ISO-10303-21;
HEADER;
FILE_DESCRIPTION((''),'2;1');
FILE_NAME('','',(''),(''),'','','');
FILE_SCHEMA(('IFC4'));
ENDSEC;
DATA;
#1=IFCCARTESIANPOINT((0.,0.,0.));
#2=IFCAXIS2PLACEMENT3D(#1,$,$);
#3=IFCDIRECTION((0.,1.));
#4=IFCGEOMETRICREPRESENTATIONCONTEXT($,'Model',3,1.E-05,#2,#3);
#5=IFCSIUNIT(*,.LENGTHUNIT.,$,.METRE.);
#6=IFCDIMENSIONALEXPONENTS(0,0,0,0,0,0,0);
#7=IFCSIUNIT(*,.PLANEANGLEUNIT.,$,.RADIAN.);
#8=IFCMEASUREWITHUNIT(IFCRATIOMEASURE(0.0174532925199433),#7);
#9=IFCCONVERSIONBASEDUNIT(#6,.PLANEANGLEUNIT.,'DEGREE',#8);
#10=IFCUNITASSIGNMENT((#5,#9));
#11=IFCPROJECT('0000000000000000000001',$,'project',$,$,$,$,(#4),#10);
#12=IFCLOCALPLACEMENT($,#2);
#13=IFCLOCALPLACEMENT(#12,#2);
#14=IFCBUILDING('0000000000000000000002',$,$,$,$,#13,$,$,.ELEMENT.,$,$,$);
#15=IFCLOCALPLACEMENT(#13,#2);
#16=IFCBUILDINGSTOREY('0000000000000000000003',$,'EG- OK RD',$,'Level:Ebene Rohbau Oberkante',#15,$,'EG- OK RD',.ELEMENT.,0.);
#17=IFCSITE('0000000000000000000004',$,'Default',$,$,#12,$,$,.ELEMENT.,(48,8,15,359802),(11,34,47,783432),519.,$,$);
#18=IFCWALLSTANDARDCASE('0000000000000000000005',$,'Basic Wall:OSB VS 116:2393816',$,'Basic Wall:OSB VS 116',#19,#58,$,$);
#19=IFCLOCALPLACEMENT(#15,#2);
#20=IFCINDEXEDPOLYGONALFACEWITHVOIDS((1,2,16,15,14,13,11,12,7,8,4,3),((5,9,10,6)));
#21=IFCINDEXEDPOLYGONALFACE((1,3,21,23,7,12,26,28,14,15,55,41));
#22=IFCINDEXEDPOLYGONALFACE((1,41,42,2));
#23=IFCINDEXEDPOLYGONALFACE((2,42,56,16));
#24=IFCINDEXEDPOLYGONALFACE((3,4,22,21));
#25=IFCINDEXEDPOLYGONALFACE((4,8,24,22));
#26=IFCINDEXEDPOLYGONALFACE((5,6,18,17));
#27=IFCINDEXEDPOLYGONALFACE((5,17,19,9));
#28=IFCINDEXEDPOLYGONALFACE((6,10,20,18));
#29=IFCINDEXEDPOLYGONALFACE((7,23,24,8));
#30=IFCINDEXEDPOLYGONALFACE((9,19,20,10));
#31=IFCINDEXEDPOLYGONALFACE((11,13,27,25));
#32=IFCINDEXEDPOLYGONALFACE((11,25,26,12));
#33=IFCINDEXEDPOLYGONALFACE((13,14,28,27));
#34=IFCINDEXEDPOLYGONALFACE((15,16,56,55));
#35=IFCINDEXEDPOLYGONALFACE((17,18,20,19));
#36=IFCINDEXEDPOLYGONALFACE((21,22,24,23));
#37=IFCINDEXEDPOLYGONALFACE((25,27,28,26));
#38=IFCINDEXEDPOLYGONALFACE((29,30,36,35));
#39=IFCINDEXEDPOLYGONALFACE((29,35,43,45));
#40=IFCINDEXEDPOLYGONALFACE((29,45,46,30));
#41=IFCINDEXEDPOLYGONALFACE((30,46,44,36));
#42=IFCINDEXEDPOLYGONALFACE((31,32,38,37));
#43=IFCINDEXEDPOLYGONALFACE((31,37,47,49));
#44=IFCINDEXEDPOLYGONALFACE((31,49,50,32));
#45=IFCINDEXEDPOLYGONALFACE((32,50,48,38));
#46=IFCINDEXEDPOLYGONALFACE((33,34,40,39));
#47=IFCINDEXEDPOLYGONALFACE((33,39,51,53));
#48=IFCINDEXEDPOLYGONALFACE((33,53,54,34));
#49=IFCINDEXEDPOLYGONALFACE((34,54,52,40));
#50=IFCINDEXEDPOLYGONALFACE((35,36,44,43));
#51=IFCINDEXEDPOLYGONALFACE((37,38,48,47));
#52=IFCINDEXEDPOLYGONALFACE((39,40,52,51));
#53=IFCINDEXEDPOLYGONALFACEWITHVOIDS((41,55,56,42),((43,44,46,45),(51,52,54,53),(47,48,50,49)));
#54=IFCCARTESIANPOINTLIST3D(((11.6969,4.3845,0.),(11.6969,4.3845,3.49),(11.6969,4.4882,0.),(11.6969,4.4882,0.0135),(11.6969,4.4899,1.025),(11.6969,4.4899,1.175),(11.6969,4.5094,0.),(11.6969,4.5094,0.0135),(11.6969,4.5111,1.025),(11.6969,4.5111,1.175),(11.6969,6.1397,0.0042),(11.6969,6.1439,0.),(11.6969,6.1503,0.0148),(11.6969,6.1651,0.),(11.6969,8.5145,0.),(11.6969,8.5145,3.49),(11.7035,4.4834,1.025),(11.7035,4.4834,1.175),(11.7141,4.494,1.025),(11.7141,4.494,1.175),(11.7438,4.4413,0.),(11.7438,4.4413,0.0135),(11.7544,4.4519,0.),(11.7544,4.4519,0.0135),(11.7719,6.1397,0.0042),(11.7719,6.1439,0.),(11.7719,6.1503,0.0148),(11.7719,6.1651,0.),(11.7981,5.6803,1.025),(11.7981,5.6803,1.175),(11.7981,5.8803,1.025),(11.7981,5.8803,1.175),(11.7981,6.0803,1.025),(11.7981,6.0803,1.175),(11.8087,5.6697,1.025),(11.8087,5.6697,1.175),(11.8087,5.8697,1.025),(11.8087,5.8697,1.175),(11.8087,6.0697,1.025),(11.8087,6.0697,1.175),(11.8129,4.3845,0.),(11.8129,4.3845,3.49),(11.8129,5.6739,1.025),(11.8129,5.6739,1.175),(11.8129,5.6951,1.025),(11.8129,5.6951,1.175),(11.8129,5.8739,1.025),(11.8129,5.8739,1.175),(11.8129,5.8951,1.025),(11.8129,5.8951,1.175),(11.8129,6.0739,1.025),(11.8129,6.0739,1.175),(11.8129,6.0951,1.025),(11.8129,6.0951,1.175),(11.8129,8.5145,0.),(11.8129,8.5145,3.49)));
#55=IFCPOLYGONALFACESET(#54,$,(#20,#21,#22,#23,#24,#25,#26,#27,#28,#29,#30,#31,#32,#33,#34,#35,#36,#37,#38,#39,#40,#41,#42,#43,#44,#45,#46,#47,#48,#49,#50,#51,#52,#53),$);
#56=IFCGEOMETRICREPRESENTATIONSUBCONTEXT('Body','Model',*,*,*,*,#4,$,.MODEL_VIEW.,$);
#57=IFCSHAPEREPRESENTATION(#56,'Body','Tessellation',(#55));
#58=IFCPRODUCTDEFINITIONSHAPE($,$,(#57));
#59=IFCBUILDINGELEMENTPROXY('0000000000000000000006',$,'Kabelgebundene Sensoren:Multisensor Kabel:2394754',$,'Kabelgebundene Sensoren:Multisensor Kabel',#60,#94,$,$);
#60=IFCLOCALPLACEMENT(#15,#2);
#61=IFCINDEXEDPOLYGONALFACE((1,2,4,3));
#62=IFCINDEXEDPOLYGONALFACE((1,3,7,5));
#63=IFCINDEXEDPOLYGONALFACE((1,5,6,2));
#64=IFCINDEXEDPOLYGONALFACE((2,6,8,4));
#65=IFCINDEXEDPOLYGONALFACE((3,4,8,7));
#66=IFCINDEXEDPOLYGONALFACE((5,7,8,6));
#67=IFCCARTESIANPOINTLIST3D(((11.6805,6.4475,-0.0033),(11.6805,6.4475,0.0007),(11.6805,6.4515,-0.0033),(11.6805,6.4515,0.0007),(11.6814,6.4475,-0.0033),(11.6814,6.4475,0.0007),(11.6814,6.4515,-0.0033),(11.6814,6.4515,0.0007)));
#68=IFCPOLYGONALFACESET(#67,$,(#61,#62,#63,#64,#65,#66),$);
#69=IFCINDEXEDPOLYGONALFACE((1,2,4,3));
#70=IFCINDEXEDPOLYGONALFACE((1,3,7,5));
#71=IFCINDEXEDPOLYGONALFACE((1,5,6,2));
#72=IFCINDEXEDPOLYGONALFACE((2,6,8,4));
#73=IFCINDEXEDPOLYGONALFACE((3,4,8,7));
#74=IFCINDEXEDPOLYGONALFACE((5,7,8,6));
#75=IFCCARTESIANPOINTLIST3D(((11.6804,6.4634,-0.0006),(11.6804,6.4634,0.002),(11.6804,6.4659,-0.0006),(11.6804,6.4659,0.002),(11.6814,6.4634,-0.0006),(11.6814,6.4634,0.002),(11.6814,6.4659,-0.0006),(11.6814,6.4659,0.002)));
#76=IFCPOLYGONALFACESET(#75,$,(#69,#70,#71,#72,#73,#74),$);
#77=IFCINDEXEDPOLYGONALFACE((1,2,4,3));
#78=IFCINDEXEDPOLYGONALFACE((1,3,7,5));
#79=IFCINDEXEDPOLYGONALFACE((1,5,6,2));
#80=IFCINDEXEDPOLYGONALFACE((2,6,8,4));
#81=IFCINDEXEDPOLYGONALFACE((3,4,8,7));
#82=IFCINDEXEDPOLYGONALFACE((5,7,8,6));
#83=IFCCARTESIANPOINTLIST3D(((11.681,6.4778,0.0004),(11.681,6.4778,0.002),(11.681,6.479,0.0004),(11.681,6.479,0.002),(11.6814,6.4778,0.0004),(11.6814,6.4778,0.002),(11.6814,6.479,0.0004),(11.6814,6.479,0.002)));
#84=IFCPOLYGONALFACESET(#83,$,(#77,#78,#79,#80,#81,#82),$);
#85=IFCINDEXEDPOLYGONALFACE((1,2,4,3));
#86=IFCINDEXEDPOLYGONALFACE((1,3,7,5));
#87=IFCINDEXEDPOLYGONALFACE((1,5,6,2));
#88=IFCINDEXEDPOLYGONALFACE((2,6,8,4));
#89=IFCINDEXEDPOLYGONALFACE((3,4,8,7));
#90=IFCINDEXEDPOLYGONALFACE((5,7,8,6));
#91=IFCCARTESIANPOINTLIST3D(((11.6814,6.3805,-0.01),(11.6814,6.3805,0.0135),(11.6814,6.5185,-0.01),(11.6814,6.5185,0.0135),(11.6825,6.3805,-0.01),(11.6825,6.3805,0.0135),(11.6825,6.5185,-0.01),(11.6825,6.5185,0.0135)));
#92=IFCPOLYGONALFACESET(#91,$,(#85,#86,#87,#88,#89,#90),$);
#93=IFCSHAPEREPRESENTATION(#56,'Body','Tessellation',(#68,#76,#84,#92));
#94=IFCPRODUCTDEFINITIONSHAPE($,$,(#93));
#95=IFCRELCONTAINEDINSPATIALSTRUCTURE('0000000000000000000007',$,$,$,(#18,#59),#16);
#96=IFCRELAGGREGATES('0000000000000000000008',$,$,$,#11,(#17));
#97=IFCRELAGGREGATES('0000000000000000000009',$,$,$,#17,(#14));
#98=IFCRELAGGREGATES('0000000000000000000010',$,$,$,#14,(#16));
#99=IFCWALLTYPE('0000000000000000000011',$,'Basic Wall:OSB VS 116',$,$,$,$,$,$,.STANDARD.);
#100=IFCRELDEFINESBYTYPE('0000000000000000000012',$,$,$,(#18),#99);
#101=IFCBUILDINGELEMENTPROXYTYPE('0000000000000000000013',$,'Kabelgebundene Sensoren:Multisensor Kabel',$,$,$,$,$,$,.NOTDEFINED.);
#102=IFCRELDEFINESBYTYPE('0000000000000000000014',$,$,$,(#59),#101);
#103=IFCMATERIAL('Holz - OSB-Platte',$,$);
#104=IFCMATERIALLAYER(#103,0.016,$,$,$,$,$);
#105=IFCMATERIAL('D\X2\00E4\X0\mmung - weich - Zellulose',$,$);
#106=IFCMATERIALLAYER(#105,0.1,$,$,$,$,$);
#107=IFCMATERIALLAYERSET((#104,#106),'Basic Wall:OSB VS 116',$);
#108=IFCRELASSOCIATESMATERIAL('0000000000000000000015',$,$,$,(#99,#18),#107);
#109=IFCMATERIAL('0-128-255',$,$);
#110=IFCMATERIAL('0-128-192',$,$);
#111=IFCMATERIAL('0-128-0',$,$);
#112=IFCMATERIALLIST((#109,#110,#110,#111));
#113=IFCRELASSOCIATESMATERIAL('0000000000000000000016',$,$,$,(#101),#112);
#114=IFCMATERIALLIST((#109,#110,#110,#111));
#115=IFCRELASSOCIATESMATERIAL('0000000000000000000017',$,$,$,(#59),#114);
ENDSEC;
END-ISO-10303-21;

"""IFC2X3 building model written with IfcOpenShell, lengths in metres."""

from ifc_helpers import new_model, entity, si_unit, converted_unit, direction, frame, frame_2d, origin, origin_2d_with_axis, place, context, subcontext, project, spatial, rectangle, extrude, source, transform, mapped, material, material_list, layer, layer_set, layer_usage, type_object, type_shapes, element, save


model = new_model("IFC2X3")

# Units and contexts
model_context = context("Model", 3, precision=1e-05, world=origin(), true_north=direction((0.0, 1.0)))
body_context = subcontext(model_context, "Body", "Model", "MODEL_VIEW")
ifc_project = project(units=[si_unit("LENGTHUNIT", "METRE"), converted_unit("PLANEANGLEUNIT", "DEGREE", entity("IfcRatioMeasure", 0.0174532925199433), si_unit("PLANEANGLEUNIT", "RADIAN"), dimensions=[0, 0, 0, 0, 0, 0, 0])], contexts=[model_context])

# Site, building, storey
site_placement = place(None, origin())
site = spatial("IfcSite", under=ifc_project, at=site_placement, Name="Default", CompositionType="ELEMENT", RefLatitude=(48, 8, 15, 359802), RefLongitude=(11, 34, 47, 783432), RefElevation=519.0)
building_placement = place(site_placement, origin())
building = spatial("IfcBuilding", under=site, at=building_placement, CompositionType="ELEMENT")
storey_placement = place(building_placement, origin())
storey = spatial("IfcBuildingStorey", under=building, at=storey_placement, Name="EG- OK RD", ObjectType="Level:Ebene Rohbau Oberkante", LongName="EG- OK RD", CompositionType="ELEMENT", Elevation=0.0)

# Wall, openings
ifc_material_1 = material(Name="Holz - OSB-Platte")
ifc_layer_1 = layer(ifc_material_1, 0.016)
ifc_material_2 = material(Name="Dämmung - weich - Zellulose")
ifc_layer_2 = layer(ifc_material_2, 0.1)
ifc_layer_set_1 = layer_set([ifc_layer_1, ifc_layer_2], Name="Basic Wall:OSB VS 116")
ifc_layer_usage_1 = layer_usage(ifc_layer_set_1, "AXIS2", "NEGATIVE", 0.058)
wall_type_1 = type_object("IfcWallType", Name="Basic Wall:OSB VS 116", PredefinedType="STANDARD", material=ifc_layer_set_1)
wall_1_placement = place(storey_placement, frame((11.7549, 4.3845, 0.0), z_axis=(0.0, 0.0, 1.0), x_axis=(0.0, 1.0, 0.0)))
wall_1 = element("IfcWallStandardCase", 1, at=wall_1_placement, inside=storey, type_object=wall_type_1, material=ifc_layer_usage_1, Name="Basic Wall:OSB VS 116:2393816", ObjectType="Basic Wall:OSB VS 116", context=body_context, shape_type="SweptSolid", body=[
    extrude(rectangle(XDim=4.13, YDim=0.116, at=frame_2d((2.065, 0.0), x_axis=(-1.0, 0.0))), origin(), (0.0, 0.0, 1.0), 3.49),
])
opening_1_placement = place(wall_1_placement, origin())
element("IfcOpeningElement", 2, at=opening_1_placement, cuts=wall_1, ObjectType="Recess", context=body_context, shape_type="SweptSolid", body=[
    extrude(rectangle(XDim=0.15, YDim=0.0285, at=frame_2d((0.0, 0.0), x_axis=(0.0, 1.0))), frame((1.2952, -0.0638, 1.1), z_axis=(0.707107, 0.707107, 0.0), x_axis=(0.707107, -0.707107, 0.0)), (0.0, 0.0, 1.0), 0.015),
])
opening_2_placement = place(wall_1_placement, origin())
element("IfcOpeningElement", 3, at=opening_2_placement, cuts=wall_1, ObjectType="Recess", context=body_context, shape_type="SweptSolid", body=[
    extrude(rectangle(XDim=0.15, YDim=0.0285, at=frame_2d((0.0, 0.0), x_axis=(0.0, 1.0))), frame((1.4952, -0.0638, 1.1), z_axis=(0.707107, 0.707107, 0.0), x_axis=(0.707107, -0.707107, 0.0)), (0.0, 0.0, 1.0), 0.015),
])
opening_3_placement = place(wall_1_placement, origin())
element("IfcOpeningElement", 4, at=opening_3_placement, cuts=wall_1, ObjectType="Recess", context=body_context, shape_type="SweptSolid", body=[
    extrude(rectangle(XDim=0.15, YDim=0.0285, at=frame_2d((0.0, 0.0), x_axis=(0.0, 1.0))), frame((1.6952, -0.0638, 1.1), z_axis=(0.707107, 0.707107, 0.0), x_axis=(0.707107, -0.707107, 0.0)), (0.0, 0.0, 1.0), 0.015),
])
opening_4_placement = place(wall_1_placement, origin())
element("IfcOpeningElement", 5, at=opening_4_placement, cuts=wall_1, ObjectType="Recess", context=body_context, shape_type="SweptSolid", body=[
    extrude(rectangle(XDim=0.15, YDim=0.0285, at=frame_2d((0.0, 0.0), x_axis=(0.0, 1.0))), frame((0.1195, 0.0509, 1.1), z_axis=(-0.707107, 0.707107, 0.0), x_axis=(-0.707107, -0.707107, 0.0)), (0.0, 0.0, 1.0), 0.015),
])
opening_5_placement = place(wall_1_placement, origin())
element("IfcOpeningElement", 6, at=opening_5_placement, cuts=wall_1, ObjectType="Recess", context=body_context, shape_type="SweptSolid", body=[
    extrude(rectangle(XDim=0.0285, YDim=0.15, at=frame_2d((0.0, 0.0), x_axis=(1.0, 0.0))), frame((0.1205, 0.0535, -0.0007), z_axis=(-0.707107, 0.707107, 0.0), x_axis=(0.0, 0.0, -1.0)), (0.0, 0.0, 1.0), 0.015),
])
opening_6_placement = place(wall_1_placement, origin())
element("IfcOpeningElement", 7, at=opening_6_placement, cuts=wall_1, ObjectType="Opening", context=body_context, shape_type="SweptSolid", body=[
    extrude(rectangle(XDim=0.0285, YDim=0.015, at=origin_2d_with_axis()), frame((1.7705, -0.017, -0.0005), z_axis=(0.0, 1.0, 0.0), x_axis=(0.707107, 0.0, -0.707107)), (0.0, 0.0, 1.0), 0.15),
])

# Building element proxy
ifc_material_3 = material(Name="0-128-255")
ifc_material_4 = material(Name="0-128-192")
ifc_material_5 = material(Name="0-128-0")
ifc_material_list_1 = material_list([ifc_material_3, ifc_material_4, ifc_material_4, ifc_material_5])
ifc_material_list_2 = material_list([ifc_material_3, ifc_material_4, ifc_material_4, ifc_material_5])
building_element_proxy_type = type_object("IfcBuildingElementProxyType", Name="Kabelgebundene Sensoren:Multisensor Kabel", PredefinedType="NOTDEFINED", material=ifc_material_list_2)
shared_shape = source(origin(), body_context, "Body", "SweptSolid", [
    extrude(rectangle(XDim=0.0009, YDim=0.004, at=frame_2d((0.0, 0.0), x_axis=(1.0, 0.0))), frame((0.0, 0.001, -0.0033), z_axis=(0.0, 0.0, 1.0), x_axis=(0.0, -1.0, 0.0)), (0.0, 0.0, 1.0), 0.004),
    extrude(rectangle(XDim=0.001, YDim=0.0025, at=frame_2d((0.0, 0.0), x_axis=(1.0, 0.0))), frame((0.0152, 0.001, -0.0006), z_axis=(0.0, 0.0, 1.0), x_axis=(0.0, -1.0, 0.0)), (0.0, 0.0, 1.0), 0.0026),
    extrude(rectangle(XDim=0.0004, YDim=0.0012, at=frame_2d((0.0, 0.0), x_axis=(1.0, 0.0))), frame((0.0289, 0.0007, 0.0004), z_axis=(0.0, 0.0, 1.0), x_axis=(0.0, -1.0, 0.0)), (0.0, 0.0, 1.0), 0.0016),
    extrude(rectangle(XDim=0.0011, YDim=0.138, at=origin_2d_with_axis()), frame((0.0, 0.0, -0.01), z_axis=(0.0, 0.0, 1.0), x_axis=(0.0, 1.0, 0.0)), (0.0, 0.0, 1.0), 0.0235),
])
type_shapes(building_element_proxy_type, [shared_shape])
proxy_placement = place(storey_placement, frame((11.6819, 6.4495, 0.0), z_axis=(0.0, 0.0, 1.0), x_axis=(0.0, 1.0, 0.0)))
element("IfcBuildingElementProxy", 8, at=proxy_placement, inside=storey, type_object=building_element_proxy_type, material=ifc_material_list_1, Name="Kabelgebundene Sensoren:Multisensor Kabel:2394754", ObjectType="Kabelgebundene Sensoren:Multisensor Kabel", context=body_context, shape_type="MappedRepresentation", body=[
    mapped(shared_shape, transform((0.0, 0.0, 0.0), scale=1.0)),
])

save(model, "model.ifc")
